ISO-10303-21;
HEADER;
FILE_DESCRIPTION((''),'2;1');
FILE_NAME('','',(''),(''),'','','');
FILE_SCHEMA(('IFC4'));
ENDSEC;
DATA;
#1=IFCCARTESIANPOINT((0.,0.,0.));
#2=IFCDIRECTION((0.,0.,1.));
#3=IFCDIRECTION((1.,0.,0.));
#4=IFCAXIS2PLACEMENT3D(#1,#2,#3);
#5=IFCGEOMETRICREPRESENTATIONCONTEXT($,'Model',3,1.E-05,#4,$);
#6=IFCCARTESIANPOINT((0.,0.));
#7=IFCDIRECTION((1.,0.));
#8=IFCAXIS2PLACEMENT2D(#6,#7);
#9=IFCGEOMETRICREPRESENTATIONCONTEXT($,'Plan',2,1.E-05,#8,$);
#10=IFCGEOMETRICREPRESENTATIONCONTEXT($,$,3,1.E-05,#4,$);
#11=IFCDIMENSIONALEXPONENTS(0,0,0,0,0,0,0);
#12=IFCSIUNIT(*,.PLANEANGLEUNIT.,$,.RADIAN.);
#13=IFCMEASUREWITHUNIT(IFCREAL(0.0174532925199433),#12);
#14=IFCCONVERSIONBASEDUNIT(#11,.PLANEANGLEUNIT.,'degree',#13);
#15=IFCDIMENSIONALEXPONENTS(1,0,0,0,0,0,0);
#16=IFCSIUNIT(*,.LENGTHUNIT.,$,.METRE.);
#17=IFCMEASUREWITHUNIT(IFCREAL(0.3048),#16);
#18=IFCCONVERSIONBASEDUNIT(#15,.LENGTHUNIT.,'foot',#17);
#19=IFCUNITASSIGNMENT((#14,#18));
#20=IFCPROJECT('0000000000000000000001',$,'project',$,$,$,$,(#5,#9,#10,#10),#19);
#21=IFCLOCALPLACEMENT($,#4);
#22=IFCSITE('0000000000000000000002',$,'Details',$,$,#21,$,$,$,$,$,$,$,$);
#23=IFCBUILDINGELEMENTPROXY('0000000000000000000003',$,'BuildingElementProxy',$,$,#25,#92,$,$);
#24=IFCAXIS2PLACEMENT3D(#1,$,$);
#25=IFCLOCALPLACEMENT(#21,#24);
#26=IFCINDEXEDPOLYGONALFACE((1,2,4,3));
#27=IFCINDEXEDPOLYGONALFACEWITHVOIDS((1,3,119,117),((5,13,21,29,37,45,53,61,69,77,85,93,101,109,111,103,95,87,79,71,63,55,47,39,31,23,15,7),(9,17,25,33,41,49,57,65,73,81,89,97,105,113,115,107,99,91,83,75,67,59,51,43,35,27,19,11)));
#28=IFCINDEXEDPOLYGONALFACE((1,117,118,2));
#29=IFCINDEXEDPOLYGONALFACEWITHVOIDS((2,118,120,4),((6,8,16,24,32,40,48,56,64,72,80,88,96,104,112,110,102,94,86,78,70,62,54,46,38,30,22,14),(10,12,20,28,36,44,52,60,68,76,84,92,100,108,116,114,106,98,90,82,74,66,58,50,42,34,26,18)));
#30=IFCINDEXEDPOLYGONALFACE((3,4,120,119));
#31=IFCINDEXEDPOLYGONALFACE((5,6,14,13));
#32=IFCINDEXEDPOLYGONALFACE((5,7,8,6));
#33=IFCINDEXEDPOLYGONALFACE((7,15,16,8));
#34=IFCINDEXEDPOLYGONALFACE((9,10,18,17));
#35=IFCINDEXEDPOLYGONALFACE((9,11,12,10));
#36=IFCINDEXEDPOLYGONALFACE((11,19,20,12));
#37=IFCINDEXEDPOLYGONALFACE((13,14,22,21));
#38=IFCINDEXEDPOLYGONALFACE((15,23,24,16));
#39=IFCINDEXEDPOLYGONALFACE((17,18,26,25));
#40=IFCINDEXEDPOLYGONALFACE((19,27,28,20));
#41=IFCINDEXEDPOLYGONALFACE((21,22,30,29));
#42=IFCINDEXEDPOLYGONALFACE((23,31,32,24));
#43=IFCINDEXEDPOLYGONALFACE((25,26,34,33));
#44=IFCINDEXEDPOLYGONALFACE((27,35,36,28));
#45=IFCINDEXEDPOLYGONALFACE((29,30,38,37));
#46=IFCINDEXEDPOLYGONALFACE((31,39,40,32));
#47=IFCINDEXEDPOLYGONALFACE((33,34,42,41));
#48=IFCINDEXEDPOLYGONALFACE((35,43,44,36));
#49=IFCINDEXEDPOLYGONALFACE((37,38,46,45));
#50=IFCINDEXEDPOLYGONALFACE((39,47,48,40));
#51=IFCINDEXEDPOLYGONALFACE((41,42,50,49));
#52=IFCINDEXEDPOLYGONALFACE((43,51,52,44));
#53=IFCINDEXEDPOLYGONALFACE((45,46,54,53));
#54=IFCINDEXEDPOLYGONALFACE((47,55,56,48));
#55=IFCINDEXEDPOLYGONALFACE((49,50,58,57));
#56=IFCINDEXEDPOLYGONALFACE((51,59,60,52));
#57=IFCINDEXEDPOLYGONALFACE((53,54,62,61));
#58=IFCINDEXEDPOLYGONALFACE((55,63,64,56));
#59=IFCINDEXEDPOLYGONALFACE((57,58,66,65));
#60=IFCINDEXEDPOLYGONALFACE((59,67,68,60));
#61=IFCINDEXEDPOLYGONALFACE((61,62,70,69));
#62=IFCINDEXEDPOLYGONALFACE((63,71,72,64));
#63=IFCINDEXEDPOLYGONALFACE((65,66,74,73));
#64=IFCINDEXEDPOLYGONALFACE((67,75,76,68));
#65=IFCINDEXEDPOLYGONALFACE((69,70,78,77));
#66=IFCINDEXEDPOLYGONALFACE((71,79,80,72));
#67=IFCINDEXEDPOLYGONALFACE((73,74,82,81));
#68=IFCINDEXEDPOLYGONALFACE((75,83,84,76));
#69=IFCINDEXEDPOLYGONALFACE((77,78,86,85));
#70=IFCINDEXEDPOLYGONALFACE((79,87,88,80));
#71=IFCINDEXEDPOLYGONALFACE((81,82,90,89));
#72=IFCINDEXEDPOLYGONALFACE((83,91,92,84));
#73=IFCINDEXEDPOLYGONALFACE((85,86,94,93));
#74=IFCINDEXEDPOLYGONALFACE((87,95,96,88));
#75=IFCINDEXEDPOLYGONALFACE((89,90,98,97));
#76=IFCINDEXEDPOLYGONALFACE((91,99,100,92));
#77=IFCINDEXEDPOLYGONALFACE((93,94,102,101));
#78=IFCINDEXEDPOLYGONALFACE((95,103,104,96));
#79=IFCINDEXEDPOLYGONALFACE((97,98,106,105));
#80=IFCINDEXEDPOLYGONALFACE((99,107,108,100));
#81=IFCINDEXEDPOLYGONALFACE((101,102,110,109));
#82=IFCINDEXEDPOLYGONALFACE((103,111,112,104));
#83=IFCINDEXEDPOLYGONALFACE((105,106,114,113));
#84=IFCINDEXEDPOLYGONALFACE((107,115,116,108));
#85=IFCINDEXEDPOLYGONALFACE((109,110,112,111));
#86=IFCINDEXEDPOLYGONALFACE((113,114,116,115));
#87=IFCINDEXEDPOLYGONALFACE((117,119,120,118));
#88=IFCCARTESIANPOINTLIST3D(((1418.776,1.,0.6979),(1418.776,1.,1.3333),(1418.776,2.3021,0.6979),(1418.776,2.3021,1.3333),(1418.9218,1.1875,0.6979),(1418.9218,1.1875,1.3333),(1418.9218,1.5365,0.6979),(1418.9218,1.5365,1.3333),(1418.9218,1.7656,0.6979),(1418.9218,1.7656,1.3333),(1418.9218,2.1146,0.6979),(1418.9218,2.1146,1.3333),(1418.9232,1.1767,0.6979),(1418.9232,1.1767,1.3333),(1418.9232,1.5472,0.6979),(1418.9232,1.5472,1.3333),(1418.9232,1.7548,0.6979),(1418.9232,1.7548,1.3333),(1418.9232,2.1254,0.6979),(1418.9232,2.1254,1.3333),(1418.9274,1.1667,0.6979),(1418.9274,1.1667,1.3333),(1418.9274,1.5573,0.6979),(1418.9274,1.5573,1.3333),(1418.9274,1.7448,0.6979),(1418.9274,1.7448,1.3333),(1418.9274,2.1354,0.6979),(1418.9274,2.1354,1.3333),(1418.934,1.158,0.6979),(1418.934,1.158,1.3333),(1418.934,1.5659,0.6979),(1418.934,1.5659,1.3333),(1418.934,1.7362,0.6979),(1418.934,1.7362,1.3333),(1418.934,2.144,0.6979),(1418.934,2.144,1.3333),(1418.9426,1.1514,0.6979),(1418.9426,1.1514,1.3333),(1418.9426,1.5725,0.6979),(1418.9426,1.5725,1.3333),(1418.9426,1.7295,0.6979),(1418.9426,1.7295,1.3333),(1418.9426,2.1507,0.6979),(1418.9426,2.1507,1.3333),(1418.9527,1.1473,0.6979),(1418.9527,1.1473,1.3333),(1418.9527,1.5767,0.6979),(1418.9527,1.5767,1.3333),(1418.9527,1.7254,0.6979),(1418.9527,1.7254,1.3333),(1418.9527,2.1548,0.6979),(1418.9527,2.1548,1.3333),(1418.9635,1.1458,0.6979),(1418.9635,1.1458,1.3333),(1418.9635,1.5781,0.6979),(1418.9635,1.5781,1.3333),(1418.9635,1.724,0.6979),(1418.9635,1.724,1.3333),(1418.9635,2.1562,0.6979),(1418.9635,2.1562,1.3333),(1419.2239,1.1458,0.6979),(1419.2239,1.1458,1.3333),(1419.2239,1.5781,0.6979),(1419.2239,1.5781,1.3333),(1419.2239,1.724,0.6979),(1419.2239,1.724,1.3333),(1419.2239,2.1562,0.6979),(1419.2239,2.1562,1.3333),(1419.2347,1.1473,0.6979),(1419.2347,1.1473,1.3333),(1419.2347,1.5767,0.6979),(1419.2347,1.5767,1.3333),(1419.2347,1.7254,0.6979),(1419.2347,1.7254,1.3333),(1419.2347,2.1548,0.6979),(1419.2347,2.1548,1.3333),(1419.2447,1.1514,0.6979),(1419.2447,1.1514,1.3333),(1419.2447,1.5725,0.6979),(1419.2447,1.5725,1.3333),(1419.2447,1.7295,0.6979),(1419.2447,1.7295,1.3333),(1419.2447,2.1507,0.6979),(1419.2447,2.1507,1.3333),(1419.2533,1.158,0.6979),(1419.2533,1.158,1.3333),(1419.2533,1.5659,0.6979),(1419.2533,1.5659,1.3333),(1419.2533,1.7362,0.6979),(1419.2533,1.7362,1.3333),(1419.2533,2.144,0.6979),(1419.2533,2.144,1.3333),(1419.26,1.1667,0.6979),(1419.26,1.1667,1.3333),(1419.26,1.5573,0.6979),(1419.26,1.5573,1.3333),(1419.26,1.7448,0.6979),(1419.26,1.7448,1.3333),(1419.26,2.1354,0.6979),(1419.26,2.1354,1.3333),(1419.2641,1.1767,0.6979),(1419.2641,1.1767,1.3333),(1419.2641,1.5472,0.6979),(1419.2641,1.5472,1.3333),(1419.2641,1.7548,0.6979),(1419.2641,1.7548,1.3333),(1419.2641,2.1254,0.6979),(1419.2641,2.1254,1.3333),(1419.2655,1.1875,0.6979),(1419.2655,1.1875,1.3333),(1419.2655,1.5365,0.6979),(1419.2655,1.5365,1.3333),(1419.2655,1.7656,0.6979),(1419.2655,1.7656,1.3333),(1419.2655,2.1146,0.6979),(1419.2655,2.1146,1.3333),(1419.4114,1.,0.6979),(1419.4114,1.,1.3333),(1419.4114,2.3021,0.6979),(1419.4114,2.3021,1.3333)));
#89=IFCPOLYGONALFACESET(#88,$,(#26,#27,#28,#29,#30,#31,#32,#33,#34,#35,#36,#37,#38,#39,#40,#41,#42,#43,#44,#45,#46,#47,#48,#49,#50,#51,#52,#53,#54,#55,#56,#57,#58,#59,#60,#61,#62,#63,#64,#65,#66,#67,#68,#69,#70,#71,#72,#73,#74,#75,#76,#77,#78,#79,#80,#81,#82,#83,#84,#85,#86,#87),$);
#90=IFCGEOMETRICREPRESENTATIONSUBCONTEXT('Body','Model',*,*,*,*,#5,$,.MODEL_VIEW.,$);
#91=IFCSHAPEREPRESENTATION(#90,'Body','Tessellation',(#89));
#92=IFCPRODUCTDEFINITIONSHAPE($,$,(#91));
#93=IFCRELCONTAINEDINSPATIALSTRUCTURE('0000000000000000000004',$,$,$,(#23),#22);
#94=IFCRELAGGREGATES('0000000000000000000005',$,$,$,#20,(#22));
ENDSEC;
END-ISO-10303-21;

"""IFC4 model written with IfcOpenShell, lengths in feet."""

from ifc_helpers import new_model, entity, si_unit, converted_unit, frame, origin_with_axes, origin_2d_with_axis, place, context, subcontext, project, spatial, line, indexed_curve, outline, extrude, element, save


model = new_model("IFC4")

# Units and contexts
model_context = context("Model", 3, precision=1e-05, world=origin_with_axes())
plan_context = context("Plan", 2, precision=1e-05, world=origin_2d_with_axis())
context_of_model = context(None, 3, precision=1e-05, world=origin_with_axes())
body_context = subcontext(model_context, "Body", "Model", "MODEL_VIEW")
ifc_project = project(units=[converted_unit("PLANEANGLEUNIT", "degree", entity("IfcReal", 0.0174532925199433), si_unit("PLANEANGLEUNIT", "RADIAN"), dimensions=[0, 0, 0, 0, 0, 0, 0]), converted_unit("LENGTHUNIT", "foot", entity("IfcReal", 0.3048), si_unit("LENGTHUNIT", "METRE"), dimensions=[1, 0, 0, 0, 0, 0, 0])], contexts=[model_context, plan_context, context_of_model, context_of_model])

# Site
site_placement = place(None, origin_with_axes())
site = spatial("IfcSite", under=ifc_project, at=site_placement, Name="Details")

# Building element proxy
proxy_1_placement = place(site_placement, frame((1419.0936, 2.3021, 0.6979), z_axis=(0.0, 0.0, 1.0), x_axis=(0.0, 1.0, 0.0)))
element("IfcBuildingElementProxy", 1, at=proxy_1_placement, inside=site, Name="BuildingElementProxy", context=body_context, shape_type="SweptSolid", body=[
    extrude(outline(indexed_curve([(-0.3177, -0.651), (0.3177, -0.651), (0.3177, 0.651), (-0.3177, 0.651), (0.1719, -0.1146), (0.1719, -0.4635), (0.1705, -0.4743), (0.1663, -0.4844), (0.1597, -0.493), (0.151, -0.4996), (0.141, -0.5038), (0.1302, -0.5052), (-0.1302, -0.5052), (-0.141, -0.5038), (-0.151, -0.4996), (-0.1597, -0.493), (-0.1663, -0.4844), (-0.1705, -0.4743), (-0.1719, -0.4635), (-0.1719, -0.1146), (-0.1705, -0.1038), (-0.1663, -0.0938), (-0.1597, -0.0851), (-0.151, -0.0785), (-0.141, -0.0743), (-0.1302, -0.0729), (0.1302, -0.0729), (0.141, -0.0743), (0.151, -0.0785), (0.1597, -0.0851), (0.1663, -0.0938), (0.1705, -0.1038), (0.151, 0.0785), (0.141, 0.0743), (0.1302, 0.0729), (-0.1302, 0.0729), (-0.141, 0.0743), (-0.151, 0.0785), (-0.1597, 0.0851), (-0.1663, 0.0937), (-0.1705, 0.1038), (-0.1719, 0.1146), (-0.1719, 0.4635), (-0.1705, 0.4743), (-0.1663, 0.4844), (-0.1597, 0.493), (-0.151, 0.4996), (-0.141, 0.5038), (-0.1302, 0.5052), (0.1302, 0.5052), (0.141, 0.5038), (0.151, 0.4996), (0.1597, 0.493), (0.1663, 0.4844), (0.1705, 0.4743), (0.1719, 0.4635), (0.1719, 0.1146), (0.1705, 0.1038), (0.1663, 0.0937), (0.1597, 0.0851)], segments=[line(4, 3), line(3, 2), line(2, 1), line(1, 4)], self_intersect=False), holes=[indexed_curve([(-0.3177, -0.651), (0.3177, -0.651), (0.3177, 0.651), (-0.3177, 0.651), (0.1719, -0.1146), (0.1719, -0.4635), (0.1705, -0.4743), (0.1663, -0.4844), (0.1597, -0.493), (0.151, -0.4996), (0.141, -0.5038), (0.1302, -0.5052), (-0.1302, -0.5052), (-0.141, -0.5038), (-0.151, -0.4996), (-0.1597, -0.493), (-0.1663, -0.4844), (-0.1705, -0.4743), (-0.1719, -0.4635), (-0.1719, -0.1146), (-0.1705, -0.1038), (-0.1663, -0.0938), (-0.1597, -0.0851), (-0.151, -0.0785), (-0.141, -0.0743), (-0.1302, -0.0729), (0.1302, -0.0729), (0.141, -0.0743), (0.151, -0.0785), (0.1597, -0.0851), (0.1663, -0.0938), (0.1705, -0.1038), (0.151, 0.0785), (0.141, 0.0743), (0.1302, 0.0729), (-0.1302, 0.0729), (-0.141, 0.0743), (-0.151, 0.0785), (-0.1597, 0.0851), (-0.1663, 0.0937), (-0.1705, 0.1038), (-0.1719, 0.1146), (-0.1719, 0.4635), (-0.1705, 0.4743), (-0.1663, 0.4844), (-0.1597, 0.493), (-0.151, 0.4996), (-0.141, 0.5038), (-0.1302, 0.5052), (0.1302, 0.5052), (0.141, 0.5038), (0.151, 0.4996), (0.1597, 0.493), (0.1663, 0.4844), (0.1705, 0.4743), (0.1719, 0.4635), (0.1719, 0.1146), (0.1705, 0.1038), (0.1663, 0.0937), (0.1597, 0.0851)], segments=[line(20, 19), line(19, 18), line(18, 17), line(17, 16), line(16, 15), line(15, 14), line(14, 13), line(13, 12), line(12, 11), line(11, 10), line(10, 9), line(9, 8), line(8, 7), line(7, 6), line(6, 5), line(5, 32), line(32, 31), line(31, 30), line(30, 29), line(29, 28), line(28, 27), line(27, 26), line(26, 25), line(25, 24), line(24, 23), line(23, 22), line(22, 21), line(21, 20)], self_intersect=False), indexed_curve([(-0.3177, -0.651), (0.3177, -0.651), (0.3177, 0.651), (-0.3177, 0.651), (0.1719, -0.1146), (0.1719, -0.4635), (0.1705, -0.4743), (0.1663, -0.4844), (0.1597, -0.493), (0.151, -0.4996), (0.141, -0.5038), (0.1302, -0.5052), (-0.1302, -0.5052), (-0.141, -0.5038), (-0.151, -0.4996), (-0.1597, -0.493), (-0.1663, -0.4844), (-0.1705, -0.4743), (-0.1719, -0.4635), (-0.1719, -0.1146), (-0.1705, -0.1038), (-0.1663, -0.0938), (-0.1597, -0.0851), (-0.151, -0.0785), (-0.141, -0.0743), (-0.1302, -0.0729), (0.1302, -0.0729), (0.141, -0.0743), (0.151, -0.0785), (0.1597, -0.0851), (0.1663, -0.0938), (0.1705, -0.1038), (0.151, 0.0785), (0.141, 0.0743), (0.1302, 0.0729), (-0.1302, 0.0729), (-0.141, 0.0743), (-0.151, 0.0785), (-0.1597, 0.0851), (-0.1663, 0.0937), (-0.1705, 0.1038), (-0.1719, 0.1146), (-0.1719, 0.4635), (-0.1705, 0.4743), (-0.1663, 0.4844), (-0.1597, 0.493), (-0.151, 0.4996), (-0.141, 0.5038), (-0.1302, 0.5052), (0.1302, 0.5052), (0.141, 0.5038), (0.151, 0.4996), (0.1597, 0.493), (0.1663, 0.4844), (0.1705, 0.4743), (0.1719, 0.4635), (0.1719, 0.1146), (0.1705, 0.1038), (0.1663, 0.0937), (0.1597, 0.0851)], segments=[line(44, 43), line(43, 42), line(42, 41), line(41, 40), line(40, 39), line(39, 38), line(38, 37), line(37, 36), line(36, 35), line(35, 34), line(34, 33), line(33, 60), line(60, 59), line(59, 58), line(58, 57), line(57, 56), line(56, 55), line(55, 54), line(54, 53), line(53, 52), line(52, 51), line(51, 50), line(50, 49), line(49, 48), line(48, 47), line(47, 46), line(46, 45), line(45, 44)], self_intersect=False)]), frame((-0.651, 0.0, 0.0), z_axis=(0.0, 0.0, 1.0), x_axis=(0.0, -1.0, 0.0)), (0.0, 0.0, 1.0), 0.6354),
])

save(model, "model.ifc")
